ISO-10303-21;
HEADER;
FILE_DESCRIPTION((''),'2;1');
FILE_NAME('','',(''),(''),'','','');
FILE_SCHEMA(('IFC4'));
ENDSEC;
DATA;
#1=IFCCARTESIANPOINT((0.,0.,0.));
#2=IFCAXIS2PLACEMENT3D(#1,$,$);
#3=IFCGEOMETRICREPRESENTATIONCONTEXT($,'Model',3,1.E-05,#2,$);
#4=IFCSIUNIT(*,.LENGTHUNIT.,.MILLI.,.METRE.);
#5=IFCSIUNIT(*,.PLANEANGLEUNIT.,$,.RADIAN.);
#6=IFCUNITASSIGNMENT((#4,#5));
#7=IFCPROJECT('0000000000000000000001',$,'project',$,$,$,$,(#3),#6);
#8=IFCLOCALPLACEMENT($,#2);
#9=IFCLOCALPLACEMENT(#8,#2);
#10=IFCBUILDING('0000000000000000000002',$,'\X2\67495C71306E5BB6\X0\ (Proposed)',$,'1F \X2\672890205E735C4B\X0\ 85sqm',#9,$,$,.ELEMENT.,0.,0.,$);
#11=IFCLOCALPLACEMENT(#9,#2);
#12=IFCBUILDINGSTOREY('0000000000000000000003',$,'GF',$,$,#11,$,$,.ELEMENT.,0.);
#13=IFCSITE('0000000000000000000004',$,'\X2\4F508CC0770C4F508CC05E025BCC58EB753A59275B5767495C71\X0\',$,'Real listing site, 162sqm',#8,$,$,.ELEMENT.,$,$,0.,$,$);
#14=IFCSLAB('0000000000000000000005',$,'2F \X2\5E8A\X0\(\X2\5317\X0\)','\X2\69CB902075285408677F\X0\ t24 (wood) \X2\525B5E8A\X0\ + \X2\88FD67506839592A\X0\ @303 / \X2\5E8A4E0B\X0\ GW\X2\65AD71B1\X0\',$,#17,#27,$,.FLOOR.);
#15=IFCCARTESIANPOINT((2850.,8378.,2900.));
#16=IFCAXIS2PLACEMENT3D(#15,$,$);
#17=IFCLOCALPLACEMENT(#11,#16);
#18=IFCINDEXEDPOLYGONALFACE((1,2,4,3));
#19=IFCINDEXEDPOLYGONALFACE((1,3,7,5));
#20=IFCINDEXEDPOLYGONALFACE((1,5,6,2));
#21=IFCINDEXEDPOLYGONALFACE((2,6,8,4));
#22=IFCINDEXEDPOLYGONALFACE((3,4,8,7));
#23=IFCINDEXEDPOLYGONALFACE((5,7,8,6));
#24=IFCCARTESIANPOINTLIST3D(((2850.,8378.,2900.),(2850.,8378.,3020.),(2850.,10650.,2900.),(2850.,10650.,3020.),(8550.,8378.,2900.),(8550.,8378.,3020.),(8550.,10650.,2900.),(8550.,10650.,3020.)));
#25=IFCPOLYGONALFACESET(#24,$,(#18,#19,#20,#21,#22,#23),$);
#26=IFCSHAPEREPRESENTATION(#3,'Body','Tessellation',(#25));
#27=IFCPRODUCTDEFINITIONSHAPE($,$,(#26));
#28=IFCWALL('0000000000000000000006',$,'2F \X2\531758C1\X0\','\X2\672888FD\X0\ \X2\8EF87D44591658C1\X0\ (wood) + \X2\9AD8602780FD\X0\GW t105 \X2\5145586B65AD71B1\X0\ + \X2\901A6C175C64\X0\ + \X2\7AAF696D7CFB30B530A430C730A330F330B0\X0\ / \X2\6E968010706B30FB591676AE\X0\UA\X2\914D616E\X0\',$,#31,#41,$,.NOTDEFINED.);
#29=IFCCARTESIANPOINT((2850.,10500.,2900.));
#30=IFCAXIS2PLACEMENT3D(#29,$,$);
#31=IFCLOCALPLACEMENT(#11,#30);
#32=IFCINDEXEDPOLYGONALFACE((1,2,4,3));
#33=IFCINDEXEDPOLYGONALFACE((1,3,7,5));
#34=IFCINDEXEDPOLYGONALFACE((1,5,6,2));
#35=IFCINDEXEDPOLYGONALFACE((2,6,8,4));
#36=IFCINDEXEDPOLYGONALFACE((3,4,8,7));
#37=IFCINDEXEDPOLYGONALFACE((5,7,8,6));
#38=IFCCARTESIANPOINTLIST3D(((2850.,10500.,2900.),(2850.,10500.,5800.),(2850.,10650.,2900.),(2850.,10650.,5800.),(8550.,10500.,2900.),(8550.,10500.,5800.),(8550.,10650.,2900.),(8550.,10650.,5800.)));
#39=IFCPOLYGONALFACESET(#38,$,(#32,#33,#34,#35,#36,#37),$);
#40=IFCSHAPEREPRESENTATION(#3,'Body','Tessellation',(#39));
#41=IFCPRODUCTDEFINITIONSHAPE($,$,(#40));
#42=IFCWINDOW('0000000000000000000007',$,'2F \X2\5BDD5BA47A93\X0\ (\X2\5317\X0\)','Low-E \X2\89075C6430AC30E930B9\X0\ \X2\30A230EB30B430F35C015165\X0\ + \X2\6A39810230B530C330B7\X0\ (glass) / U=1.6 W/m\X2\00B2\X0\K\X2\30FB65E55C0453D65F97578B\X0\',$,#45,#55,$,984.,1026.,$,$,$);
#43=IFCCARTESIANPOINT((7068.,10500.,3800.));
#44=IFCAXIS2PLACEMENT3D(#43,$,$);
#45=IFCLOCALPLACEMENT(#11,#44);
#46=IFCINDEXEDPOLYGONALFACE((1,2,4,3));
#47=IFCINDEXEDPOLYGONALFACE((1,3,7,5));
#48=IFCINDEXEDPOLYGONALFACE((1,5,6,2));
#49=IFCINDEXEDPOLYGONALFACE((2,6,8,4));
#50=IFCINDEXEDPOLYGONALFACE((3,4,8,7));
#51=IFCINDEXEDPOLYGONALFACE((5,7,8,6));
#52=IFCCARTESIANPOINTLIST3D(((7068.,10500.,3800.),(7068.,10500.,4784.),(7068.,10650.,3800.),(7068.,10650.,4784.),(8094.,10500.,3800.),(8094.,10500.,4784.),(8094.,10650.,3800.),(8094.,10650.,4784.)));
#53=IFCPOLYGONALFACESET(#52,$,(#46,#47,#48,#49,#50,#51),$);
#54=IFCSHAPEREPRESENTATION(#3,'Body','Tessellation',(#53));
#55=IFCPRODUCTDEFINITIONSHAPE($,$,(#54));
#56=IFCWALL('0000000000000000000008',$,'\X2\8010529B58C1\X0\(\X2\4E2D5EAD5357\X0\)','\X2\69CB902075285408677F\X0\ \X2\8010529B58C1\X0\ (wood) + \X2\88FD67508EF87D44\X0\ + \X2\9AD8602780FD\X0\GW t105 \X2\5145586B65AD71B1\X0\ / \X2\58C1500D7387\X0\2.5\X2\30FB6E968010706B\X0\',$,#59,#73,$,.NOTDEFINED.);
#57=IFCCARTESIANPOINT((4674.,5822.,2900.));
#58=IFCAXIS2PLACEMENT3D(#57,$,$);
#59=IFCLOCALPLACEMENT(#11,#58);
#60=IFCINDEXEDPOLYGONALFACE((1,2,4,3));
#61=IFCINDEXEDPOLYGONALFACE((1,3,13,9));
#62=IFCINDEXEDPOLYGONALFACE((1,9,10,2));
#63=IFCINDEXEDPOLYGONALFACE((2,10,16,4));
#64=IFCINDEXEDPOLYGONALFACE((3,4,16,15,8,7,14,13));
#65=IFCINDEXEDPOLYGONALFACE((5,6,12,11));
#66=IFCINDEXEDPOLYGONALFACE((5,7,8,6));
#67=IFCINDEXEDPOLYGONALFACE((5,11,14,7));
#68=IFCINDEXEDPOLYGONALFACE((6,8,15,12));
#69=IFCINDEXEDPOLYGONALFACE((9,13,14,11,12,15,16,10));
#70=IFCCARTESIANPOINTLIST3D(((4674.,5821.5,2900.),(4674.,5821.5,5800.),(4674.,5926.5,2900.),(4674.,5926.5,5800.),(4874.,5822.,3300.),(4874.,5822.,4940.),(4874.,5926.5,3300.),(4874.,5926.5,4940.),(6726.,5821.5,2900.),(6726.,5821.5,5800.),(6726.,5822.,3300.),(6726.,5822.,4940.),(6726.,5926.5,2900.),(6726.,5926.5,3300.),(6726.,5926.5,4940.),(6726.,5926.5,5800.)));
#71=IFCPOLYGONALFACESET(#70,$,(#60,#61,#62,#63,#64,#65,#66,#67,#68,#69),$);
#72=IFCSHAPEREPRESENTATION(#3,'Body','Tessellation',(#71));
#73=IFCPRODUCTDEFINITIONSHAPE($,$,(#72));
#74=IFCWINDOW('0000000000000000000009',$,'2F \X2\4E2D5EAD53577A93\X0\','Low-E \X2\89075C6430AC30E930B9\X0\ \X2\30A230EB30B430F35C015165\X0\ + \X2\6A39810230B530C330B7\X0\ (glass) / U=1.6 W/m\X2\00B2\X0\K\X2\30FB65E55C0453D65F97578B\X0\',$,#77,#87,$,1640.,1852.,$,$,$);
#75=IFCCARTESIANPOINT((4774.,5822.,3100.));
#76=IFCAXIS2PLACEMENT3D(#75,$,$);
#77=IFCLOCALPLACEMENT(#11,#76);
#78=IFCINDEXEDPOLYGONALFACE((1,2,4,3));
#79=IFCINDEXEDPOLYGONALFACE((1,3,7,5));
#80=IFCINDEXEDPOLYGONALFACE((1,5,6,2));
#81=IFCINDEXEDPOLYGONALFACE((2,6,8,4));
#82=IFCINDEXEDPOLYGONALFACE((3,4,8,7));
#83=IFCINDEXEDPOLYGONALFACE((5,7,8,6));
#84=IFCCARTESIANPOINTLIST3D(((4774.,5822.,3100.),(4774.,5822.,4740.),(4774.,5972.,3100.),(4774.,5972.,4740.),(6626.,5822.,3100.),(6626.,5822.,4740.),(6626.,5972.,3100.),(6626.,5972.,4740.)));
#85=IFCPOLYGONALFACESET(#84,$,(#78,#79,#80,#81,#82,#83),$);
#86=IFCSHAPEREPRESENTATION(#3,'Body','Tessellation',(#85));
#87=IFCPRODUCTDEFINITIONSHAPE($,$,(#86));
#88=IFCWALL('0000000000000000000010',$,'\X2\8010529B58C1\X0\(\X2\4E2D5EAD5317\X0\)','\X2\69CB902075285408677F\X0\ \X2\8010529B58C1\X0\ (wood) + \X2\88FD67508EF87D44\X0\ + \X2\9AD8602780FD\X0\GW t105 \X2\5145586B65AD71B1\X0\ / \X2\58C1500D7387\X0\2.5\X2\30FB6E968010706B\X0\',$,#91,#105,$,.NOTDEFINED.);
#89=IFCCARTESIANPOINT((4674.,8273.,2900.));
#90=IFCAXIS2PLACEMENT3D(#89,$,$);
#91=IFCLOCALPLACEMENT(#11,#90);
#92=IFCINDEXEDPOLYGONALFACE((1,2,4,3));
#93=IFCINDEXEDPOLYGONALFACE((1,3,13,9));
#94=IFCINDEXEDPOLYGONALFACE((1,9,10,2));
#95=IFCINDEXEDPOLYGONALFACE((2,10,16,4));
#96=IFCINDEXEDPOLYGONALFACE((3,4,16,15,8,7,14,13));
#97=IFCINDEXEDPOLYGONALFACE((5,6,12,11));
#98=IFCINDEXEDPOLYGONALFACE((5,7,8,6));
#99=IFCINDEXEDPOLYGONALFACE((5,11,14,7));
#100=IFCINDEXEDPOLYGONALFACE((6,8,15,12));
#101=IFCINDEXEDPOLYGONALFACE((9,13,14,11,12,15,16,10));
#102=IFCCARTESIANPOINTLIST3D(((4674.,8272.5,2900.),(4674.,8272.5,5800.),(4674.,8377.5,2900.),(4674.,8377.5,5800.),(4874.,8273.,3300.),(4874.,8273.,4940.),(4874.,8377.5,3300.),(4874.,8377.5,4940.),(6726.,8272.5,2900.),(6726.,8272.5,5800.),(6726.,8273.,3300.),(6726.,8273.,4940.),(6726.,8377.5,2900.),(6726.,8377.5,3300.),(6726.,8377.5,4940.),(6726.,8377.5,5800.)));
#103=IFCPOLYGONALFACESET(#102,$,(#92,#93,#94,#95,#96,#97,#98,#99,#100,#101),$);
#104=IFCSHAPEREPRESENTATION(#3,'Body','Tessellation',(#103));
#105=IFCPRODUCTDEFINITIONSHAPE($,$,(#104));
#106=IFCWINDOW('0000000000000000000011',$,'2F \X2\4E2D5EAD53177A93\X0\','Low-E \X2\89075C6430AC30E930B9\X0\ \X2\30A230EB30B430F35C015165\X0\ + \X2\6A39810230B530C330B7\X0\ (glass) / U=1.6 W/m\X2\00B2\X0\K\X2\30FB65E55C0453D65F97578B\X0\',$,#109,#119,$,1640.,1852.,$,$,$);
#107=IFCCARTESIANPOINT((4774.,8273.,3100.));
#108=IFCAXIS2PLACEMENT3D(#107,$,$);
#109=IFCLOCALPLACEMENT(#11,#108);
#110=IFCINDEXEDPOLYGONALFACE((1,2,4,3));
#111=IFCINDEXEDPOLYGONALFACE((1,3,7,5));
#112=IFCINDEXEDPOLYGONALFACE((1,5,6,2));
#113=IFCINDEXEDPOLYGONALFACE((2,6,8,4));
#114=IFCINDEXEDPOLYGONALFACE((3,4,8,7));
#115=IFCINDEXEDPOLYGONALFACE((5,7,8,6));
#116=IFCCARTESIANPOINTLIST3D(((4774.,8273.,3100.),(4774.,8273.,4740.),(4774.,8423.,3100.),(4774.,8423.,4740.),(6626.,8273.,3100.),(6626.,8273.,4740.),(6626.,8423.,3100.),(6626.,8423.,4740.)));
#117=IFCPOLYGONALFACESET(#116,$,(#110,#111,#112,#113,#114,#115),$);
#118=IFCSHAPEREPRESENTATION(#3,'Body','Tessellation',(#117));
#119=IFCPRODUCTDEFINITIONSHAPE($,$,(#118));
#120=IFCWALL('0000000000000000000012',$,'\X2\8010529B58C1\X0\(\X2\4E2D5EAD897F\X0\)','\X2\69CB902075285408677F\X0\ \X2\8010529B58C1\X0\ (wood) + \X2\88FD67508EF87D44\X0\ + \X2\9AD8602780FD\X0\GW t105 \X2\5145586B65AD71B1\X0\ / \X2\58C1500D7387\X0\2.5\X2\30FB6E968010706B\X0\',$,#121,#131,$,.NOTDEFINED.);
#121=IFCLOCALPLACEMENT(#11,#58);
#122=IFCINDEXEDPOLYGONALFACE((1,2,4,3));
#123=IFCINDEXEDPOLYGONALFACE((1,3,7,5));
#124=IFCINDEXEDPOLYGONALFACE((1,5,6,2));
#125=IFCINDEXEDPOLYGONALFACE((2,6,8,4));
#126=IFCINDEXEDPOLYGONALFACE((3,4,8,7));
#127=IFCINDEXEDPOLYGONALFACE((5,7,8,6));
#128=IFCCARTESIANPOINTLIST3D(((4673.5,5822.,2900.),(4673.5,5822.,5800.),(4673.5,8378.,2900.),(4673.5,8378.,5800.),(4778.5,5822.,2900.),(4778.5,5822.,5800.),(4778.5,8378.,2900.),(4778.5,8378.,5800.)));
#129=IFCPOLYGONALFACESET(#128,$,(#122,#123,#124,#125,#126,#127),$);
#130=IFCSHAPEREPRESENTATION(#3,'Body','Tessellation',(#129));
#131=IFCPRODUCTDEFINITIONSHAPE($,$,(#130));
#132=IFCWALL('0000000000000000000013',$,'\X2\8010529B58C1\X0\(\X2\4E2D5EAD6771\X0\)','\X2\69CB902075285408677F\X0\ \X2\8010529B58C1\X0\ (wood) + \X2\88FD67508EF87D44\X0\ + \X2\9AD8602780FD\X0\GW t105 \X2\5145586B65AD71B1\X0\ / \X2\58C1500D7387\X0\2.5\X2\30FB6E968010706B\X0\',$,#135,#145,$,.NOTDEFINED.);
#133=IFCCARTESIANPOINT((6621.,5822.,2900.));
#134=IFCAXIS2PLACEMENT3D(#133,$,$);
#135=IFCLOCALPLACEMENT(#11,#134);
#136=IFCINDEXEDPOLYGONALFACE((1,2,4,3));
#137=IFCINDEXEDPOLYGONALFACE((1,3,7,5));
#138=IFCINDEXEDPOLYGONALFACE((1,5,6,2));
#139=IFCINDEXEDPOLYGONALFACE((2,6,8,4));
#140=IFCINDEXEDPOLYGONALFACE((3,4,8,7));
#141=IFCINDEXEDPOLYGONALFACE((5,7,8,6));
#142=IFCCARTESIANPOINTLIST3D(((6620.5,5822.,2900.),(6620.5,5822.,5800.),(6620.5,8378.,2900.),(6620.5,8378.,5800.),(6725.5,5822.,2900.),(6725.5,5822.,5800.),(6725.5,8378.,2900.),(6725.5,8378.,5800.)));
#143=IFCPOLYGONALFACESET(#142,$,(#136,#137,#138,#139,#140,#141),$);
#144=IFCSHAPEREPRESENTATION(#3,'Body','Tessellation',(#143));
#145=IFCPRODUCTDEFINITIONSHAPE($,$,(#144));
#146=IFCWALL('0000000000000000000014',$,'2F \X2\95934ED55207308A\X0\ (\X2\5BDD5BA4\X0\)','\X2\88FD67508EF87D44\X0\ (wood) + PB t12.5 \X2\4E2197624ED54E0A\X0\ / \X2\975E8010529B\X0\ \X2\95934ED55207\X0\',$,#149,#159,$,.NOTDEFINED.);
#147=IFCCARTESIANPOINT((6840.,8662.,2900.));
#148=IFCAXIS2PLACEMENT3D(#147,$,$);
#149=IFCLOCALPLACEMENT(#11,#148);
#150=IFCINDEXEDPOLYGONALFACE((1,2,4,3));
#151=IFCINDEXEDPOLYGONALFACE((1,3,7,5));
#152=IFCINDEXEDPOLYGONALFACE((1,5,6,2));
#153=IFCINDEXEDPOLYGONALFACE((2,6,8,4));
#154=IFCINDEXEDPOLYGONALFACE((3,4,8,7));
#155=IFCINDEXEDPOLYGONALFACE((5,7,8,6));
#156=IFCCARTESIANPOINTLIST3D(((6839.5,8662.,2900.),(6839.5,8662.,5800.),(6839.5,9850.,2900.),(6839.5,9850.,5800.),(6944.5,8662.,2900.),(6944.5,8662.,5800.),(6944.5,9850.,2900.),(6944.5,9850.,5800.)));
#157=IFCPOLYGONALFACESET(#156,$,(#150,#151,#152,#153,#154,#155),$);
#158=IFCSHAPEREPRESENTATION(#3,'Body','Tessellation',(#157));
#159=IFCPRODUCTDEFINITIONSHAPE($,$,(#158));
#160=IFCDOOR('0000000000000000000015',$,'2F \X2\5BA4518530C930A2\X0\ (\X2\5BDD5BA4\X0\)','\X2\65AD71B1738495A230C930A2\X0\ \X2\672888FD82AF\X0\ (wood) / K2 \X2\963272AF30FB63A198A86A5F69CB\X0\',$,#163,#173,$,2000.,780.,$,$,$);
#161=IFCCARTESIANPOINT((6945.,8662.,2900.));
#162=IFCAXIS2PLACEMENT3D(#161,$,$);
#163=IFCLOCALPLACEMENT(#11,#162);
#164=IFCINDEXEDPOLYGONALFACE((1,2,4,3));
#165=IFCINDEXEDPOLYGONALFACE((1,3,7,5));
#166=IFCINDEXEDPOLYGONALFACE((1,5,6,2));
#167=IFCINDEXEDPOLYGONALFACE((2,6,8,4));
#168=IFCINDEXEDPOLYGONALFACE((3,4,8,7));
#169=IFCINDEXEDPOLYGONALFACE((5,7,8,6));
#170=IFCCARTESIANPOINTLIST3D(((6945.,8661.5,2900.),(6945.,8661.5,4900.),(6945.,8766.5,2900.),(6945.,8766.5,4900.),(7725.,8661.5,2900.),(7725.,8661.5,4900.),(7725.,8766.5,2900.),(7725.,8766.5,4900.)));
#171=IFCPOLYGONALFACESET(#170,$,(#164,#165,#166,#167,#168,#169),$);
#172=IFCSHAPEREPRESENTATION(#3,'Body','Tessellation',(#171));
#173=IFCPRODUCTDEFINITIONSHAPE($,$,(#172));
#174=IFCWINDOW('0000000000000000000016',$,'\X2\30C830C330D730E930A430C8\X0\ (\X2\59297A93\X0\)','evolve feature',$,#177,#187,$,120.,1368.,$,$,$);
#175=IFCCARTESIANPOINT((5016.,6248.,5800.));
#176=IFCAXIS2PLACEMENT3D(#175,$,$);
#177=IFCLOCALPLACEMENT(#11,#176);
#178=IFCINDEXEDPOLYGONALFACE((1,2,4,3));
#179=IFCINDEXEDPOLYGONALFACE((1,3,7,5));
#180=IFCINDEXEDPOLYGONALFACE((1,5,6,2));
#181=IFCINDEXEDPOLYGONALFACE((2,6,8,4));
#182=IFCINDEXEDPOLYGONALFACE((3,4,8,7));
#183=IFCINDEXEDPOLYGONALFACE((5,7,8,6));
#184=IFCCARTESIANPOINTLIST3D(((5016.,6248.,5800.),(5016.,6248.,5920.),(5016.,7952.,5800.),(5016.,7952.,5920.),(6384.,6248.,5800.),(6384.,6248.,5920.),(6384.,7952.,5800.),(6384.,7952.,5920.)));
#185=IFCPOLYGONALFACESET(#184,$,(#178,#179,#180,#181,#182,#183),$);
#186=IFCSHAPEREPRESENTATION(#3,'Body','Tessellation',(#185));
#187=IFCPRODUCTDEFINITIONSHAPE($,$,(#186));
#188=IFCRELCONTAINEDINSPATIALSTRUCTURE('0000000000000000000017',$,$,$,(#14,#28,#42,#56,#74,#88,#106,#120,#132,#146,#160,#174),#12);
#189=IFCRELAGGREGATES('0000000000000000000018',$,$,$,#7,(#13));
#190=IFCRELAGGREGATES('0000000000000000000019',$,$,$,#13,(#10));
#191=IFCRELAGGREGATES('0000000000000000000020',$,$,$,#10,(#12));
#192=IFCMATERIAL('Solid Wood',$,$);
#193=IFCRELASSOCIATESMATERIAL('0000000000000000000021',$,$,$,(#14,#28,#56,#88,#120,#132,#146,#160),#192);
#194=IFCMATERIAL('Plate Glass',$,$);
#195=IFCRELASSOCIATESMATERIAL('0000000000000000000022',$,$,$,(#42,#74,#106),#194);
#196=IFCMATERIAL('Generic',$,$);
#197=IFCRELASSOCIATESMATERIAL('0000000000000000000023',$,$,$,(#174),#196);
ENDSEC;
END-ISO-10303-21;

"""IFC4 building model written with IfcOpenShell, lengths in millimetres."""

from ifc_helpers import new_model, si_unit, frame, frame_2d, origin, place, context, project, spatial, rectangle, extrude, material, element, fill, save


model = new_model("IFC4")

# Units and contexts
model_context = context("Model", 3, precision=1e-05, world=origin())
ifc_project = project(units=[si_unit("LENGTHUNIT", "METRE", prefix="MILLI"), si_unit("PLANEANGLEUNIT", "RADIAN")], contexts=[model_context])

# Site, building, storey
site_placement = place(None, origin())
site = spatial("IfcSite", under=ifc_project, at=site_placement, Name="佐賀県佐賀市富士町大字杉山", ObjectType="Real listing site, 162sqm", CompositionType="ELEMENT", RefElevation=0.0)
building_placement = place(site_placement, origin())
building = spatial("IfcBuilding", under=site, at=building_placement, Name="杉山の家 (Proposed)", ObjectType="1F 木造平屋 85sqm", CompositionType="ELEMENT", ElevationOfRefHeight=0.0, ElevationOfTerrain=0.0)
storey_placement = place(building_placement, origin())
storey = spatial("IfcBuildingStorey", under=building, at=storey_placement, Name="GF", CompositionType="ELEMENT", Elevation=0.0)

# Slab
ifc_material_1 = material(Name="Solid Wood")
slab_placement = place(storey_placement, frame((2850.0, 8378.0, 2900.0)))
element("IfcSlab", 1, at=slab_placement, inside=storey, material=ifc_material_1, Name="2F 床(北)", Description="構造用合板 t24 (wood) 剛床 + 製材根太 @303 / 床下 GW断熱", PredefinedType="FLOOR", context=model_context, shape_type="SweptSolid", body=[
    extrude(rectangle(XDim=5700.0, YDim=2272.0, at=frame_2d((2850.0, 1136.0))), frame((2850.0, 8378.0, 2900.0)), (0.0, 0.0, 1.0), 120.0),
])

# Walls, openings, windows
wall_1_placement = place(storey_placement, frame((2850.0, 10500.0, 2900.0)))
wall_1 = element("IfcWall", 2, at=wall_1_placement, inside=storey, material=ifc_material_1, Name="2F 北壁", Description="木製 軸組外壁 (wood) + 高性能GW t105 充填断熱 + 通気層 + 窯業系サイディング / 準耐火・外皮UA配慮", PredefinedType="NOTDEFINED", context=model_context, shape_type="SweptSolid", body=[
    extrude(rectangle(XDim=5700.0, YDim=150.0, at=frame_2d((2850.0, 75.0))), frame((2850.0, 10500.0, 2900.0)), (0.0, 0.0, 1.0), 2900.0),
])
opening_1_placement = place(storey_placement, frame((7068.0, 10500.0, 3800.0)))
opening_1 = element("IfcOpeningElement", 3, at=opening_1_placement, cuts=wall_1, PredefinedType="NOTDEFINED", context=model_context, shape_type="SweptSolid", body=[
    extrude(rectangle(XDim=1026.0, YDim=150.0, at=frame_2d((513.0, 75.0))), frame((7068.0, 10500.0, 3800.0)), (0.0, 0.0, 1.0), 984.0),
])
ifc_material_2 = material(Name="Plate Glass")
window_1_placement = place(storey_placement, frame((7068.0, 10500.0, 3800.0)))
window_1 = element("IfcWindow", 4, at=window_1_placement, inside=storey, material=ifc_material_2, Name="2F 寝室窓 (北)", Description="Low-E 複層ガラス アルゴン封入 + 樹脂サッシ (glass) / U=1.6 W/m²K・日射取得型", OverallHeight=984.0, OverallWidth=1026.0, context=model_context, shape_type="SweptSolid", body=[
    extrude(rectangle(XDim=1026.0, YDim=150.0, at=frame_2d((513.0, 75.0))), frame((7068.0, 10500.0, 3800.0)), (0.0, 0.0, 1.0), 984.0),
])
fill(opening_1, window_1)
wall_2_placement = place(storey_placement, frame((4674.0, 5822.0, 2900.0)))
wall_2 = element("IfcWall", 5, at=wall_2_placement, inside=storey, material=ifc_material_1, Name="耐力壁(中庭南)", Description="構造用合板 耐力壁 (wood) + 製材軸組 + 高性能GW t105 充填断熱 / 壁倍率2.5・準耐火", PredefinedType="NOTDEFINED", context=model_context, shape_type="SweptSolid", body=[
    extrude(rectangle(XDim=2052.0, YDim=105.0, at=frame_2d((1026.0, 52.0))), frame((4674.0, 5822.0, 2900.0)), (0.0, 0.0, 1.0), 2900.0),
])
opening_2_placement = place(storey_placement, frame((4774.0, 5822.0, 3100.0)))
opening_2 = element("IfcOpeningElement", 6, at=opening_2_placement, cuts=wall_2, PredefinedType="NOTDEFINED", context=model_context, shape_type="SweptSolid", body=[
    extrude(rectangle(XDim=1852.0, YDim=150.0, at=frame_2d((926.0, 75.0))), frame((4774.0, 5822.0, 3100.0)), (0.0, 0.0, 1.0), 1640.0),
])
window_2_placement = place(storey_placement, frame((4774.0, 5822.0, 3100.0)))
window_2 = element("IfcWindow", 7, at=window_2_placement, inside=storey, material=ifc_material_2, Name="2F 中庭南窓", Description="Low-E 複層ガラス アルゴン封入 + 樹脂サッシ (glass) / U=1.6 W/m²K・日射取得型", OverallHeight=1640.0, OverallWidth=1852.0, context=model_context, shape_type="SweptSolid", body=[
    extrude(rectangle(XDim=1852.0, YDim=150.0, at=frame_2d((926.0, 75.0))), frame((4774.0, 5822.0, 3100.0)), (0.0, 0.0, 1.0), 1640.0),
])
fill(opening_2, window_2)
wall_3_placement = place(storey_placement, frame((4674.0, 8273.0, 2900.0)))
wall_3 = element("IfcWall", 8, at=wall_3_placement, inside=storey, material=ifc_material_1, Name="耐力壁(中庭北)", Description="構造用合板 耐力壁 (wood) + 製材軸組 + 高性能GW t105 充填断熱 / 壁倍率2.5・準耐火", PredefinedType="NOTDEFINED", context=model_context, shape_type="SweptSolid", body=[
    extrude(rectangle(XDim=2052.0, YDim=105.0, at=frame_2d((1026.0, 52.0))), frame((4674.0, 8273.0, 2900.0)), (0.0, 0.0, 1.0), 2900.0),
])
opening_3_placement = place(storey_placement, frame((4774.0, 8273.0, 3100.0)))
opening_3 = element("IfcOpeningElement", 9, at=opening_3_placement, cuts=wall_3, PredefinedType="NOTDEFINED", context=model_context, shape_type="SweptSolid", body=[
    extrude(rectangle(XDim=1852.0, YDim=150.0, at=frame_2d((926.0, 75.0))), frame((4774.0, 8273.0, 3100.0)), (0.0, 0.0, 1.0), 1640.0),
])
window_3_placement = place(storey_placement, frame((4774.0, 8273.0, 3100.0)))
window_3 = element("IfcWindow", 10, at=window_3_placement, inside=storey, material=ifc_material_2, Name="2F 中庭北窓", Description="Low-E 複層ガラス アルゴン封入 + 樹脂サッシ (glass) / U=1.6 W/m²K・日射取得型", OverallHeight=1640.0, OverallWidth=1852.0, context=model_context, shape_type="SweptSolid", body=[
    extrude(rectangle(XDim=1852.0, YDim=150.0, at=frame_2d((926.0, 75.0))), frame((4774.0, 8273.0, 3100.0)), (0.0, 0.0, 1.0), 1640.0),
])
fill(opening_3, window_3)

# Walls
wall_4_placement = place(storey_placement, frame((4674.0, 5822.0, 2900.0)))
element("IfcWall", 11, at=wall_4_placement, inside=storey, material=ifc_material_1, Name="耐力壁(中庭西)", Description="構造用合板 耐力壁 (wood) + 製材軸組 + 高性能GW t105 充填断熱 / 壁倍率2.5・準耐火", PredefinedType="NOTDEFINED", context=model_context, shape_type="SweptSolid", body=[
    extrude(rectangle(XDim=105.0, YDim=2556.0, at=frame_2d((52.0, 1278.0))), frame((4674.0, 5822.0, 2900.0)), (0.0, 0.0, 1.0), 2900.0),
])
wall_5_placement = place(storey_placement, frame((6621.0, 5822.0, 2900.0)))
element("IfcWall", 12, at=wall_5_placement, inside=storey, material=ifc_material_1, Name="耐力壁(中庭東)", Description="構造用合板 耐力壁 (wood) + 製材軸組 + 高性能GW t105 充填断熱 / 壁倍率2.5・準耐火", PredefinedType="NOTDEFINED", context=model_context, shape_type="SweptSolid", body=[
    extrude(rectangle(XDim=105.0, YDim=2556.0, at=frame_2d((52.0, 1278.0))), frame((6621.0, 5822.0, 2900.0)), (0.0, 0.0, 1.0), 2900.0),
])
wall_6_placement = place(storey_placement, frame((6840.0, 8662.0, 2900.0)))
element("IfcWall", 13, at=wall_6_placement, inside=storey, material=ifc_material_1, Name="2F 間仕切り (寝室)", Description="製材軸組 (wood) + PB t12.5 両面仕上 / 非耐力 間仕切", PredefinedType="NOTDEFINED", context=model_context, shape_type="SweptSolid", body=[
    extrude(rectangle(XDim=105.0, YDim=1188.0, at=frame_2d((52.0, 594.0))), frame((6840.0, 8662.0, 2900.0)), (0.0, 0.0, 1.0), 2900.0),
])

# Door
door_placement = place(storey_placement, frame((6945.0, 8662.0, 2900.0)))
element("IfcDoor", 14, at=door_placement, inside=storey, material=ifc_material_1, Name="2F 室内ドア (寝室)", Description="断熱玄関ドア 木製芯 (wood) / K2 防犯・採風機構", OverallHeight=2000.0, OverallWidth=780.0, context=model_context, shape_type="SweptSolid", body=[
    extrude(rectangle(XDim=780.0, YDim=105.0, at=frame_2d((390.0, 52.0))), frame((6945.0, 8662.0, 2900.0)), (0.0, 0.0, 1.0), 2000.0),
])

# Window
ifc_material_3 = material(Name="Generic")
window_4_placement = place(storey_placement, frame((5016.0, 6248.0, 5800.0)))
element("IfcWindow", 15, at=window_4_placement, inside=storey, material=ifc_material_3, Name="トップライト (天窓)", Description="evolve feature", OverallHeight=120.0, OverallWidth=1368.0, context=model_context, shape_type="SweptSolid", body=[
    extrude(rectangle(XDim=1368.0, YDim=1704.0, at=frame_2d((684.0, 852.0))), frame((5016.0, 6248.0, 5800.0)), (0.0, 0.0, 1.0), 120.0),
])

save(model, "model.ifc")
